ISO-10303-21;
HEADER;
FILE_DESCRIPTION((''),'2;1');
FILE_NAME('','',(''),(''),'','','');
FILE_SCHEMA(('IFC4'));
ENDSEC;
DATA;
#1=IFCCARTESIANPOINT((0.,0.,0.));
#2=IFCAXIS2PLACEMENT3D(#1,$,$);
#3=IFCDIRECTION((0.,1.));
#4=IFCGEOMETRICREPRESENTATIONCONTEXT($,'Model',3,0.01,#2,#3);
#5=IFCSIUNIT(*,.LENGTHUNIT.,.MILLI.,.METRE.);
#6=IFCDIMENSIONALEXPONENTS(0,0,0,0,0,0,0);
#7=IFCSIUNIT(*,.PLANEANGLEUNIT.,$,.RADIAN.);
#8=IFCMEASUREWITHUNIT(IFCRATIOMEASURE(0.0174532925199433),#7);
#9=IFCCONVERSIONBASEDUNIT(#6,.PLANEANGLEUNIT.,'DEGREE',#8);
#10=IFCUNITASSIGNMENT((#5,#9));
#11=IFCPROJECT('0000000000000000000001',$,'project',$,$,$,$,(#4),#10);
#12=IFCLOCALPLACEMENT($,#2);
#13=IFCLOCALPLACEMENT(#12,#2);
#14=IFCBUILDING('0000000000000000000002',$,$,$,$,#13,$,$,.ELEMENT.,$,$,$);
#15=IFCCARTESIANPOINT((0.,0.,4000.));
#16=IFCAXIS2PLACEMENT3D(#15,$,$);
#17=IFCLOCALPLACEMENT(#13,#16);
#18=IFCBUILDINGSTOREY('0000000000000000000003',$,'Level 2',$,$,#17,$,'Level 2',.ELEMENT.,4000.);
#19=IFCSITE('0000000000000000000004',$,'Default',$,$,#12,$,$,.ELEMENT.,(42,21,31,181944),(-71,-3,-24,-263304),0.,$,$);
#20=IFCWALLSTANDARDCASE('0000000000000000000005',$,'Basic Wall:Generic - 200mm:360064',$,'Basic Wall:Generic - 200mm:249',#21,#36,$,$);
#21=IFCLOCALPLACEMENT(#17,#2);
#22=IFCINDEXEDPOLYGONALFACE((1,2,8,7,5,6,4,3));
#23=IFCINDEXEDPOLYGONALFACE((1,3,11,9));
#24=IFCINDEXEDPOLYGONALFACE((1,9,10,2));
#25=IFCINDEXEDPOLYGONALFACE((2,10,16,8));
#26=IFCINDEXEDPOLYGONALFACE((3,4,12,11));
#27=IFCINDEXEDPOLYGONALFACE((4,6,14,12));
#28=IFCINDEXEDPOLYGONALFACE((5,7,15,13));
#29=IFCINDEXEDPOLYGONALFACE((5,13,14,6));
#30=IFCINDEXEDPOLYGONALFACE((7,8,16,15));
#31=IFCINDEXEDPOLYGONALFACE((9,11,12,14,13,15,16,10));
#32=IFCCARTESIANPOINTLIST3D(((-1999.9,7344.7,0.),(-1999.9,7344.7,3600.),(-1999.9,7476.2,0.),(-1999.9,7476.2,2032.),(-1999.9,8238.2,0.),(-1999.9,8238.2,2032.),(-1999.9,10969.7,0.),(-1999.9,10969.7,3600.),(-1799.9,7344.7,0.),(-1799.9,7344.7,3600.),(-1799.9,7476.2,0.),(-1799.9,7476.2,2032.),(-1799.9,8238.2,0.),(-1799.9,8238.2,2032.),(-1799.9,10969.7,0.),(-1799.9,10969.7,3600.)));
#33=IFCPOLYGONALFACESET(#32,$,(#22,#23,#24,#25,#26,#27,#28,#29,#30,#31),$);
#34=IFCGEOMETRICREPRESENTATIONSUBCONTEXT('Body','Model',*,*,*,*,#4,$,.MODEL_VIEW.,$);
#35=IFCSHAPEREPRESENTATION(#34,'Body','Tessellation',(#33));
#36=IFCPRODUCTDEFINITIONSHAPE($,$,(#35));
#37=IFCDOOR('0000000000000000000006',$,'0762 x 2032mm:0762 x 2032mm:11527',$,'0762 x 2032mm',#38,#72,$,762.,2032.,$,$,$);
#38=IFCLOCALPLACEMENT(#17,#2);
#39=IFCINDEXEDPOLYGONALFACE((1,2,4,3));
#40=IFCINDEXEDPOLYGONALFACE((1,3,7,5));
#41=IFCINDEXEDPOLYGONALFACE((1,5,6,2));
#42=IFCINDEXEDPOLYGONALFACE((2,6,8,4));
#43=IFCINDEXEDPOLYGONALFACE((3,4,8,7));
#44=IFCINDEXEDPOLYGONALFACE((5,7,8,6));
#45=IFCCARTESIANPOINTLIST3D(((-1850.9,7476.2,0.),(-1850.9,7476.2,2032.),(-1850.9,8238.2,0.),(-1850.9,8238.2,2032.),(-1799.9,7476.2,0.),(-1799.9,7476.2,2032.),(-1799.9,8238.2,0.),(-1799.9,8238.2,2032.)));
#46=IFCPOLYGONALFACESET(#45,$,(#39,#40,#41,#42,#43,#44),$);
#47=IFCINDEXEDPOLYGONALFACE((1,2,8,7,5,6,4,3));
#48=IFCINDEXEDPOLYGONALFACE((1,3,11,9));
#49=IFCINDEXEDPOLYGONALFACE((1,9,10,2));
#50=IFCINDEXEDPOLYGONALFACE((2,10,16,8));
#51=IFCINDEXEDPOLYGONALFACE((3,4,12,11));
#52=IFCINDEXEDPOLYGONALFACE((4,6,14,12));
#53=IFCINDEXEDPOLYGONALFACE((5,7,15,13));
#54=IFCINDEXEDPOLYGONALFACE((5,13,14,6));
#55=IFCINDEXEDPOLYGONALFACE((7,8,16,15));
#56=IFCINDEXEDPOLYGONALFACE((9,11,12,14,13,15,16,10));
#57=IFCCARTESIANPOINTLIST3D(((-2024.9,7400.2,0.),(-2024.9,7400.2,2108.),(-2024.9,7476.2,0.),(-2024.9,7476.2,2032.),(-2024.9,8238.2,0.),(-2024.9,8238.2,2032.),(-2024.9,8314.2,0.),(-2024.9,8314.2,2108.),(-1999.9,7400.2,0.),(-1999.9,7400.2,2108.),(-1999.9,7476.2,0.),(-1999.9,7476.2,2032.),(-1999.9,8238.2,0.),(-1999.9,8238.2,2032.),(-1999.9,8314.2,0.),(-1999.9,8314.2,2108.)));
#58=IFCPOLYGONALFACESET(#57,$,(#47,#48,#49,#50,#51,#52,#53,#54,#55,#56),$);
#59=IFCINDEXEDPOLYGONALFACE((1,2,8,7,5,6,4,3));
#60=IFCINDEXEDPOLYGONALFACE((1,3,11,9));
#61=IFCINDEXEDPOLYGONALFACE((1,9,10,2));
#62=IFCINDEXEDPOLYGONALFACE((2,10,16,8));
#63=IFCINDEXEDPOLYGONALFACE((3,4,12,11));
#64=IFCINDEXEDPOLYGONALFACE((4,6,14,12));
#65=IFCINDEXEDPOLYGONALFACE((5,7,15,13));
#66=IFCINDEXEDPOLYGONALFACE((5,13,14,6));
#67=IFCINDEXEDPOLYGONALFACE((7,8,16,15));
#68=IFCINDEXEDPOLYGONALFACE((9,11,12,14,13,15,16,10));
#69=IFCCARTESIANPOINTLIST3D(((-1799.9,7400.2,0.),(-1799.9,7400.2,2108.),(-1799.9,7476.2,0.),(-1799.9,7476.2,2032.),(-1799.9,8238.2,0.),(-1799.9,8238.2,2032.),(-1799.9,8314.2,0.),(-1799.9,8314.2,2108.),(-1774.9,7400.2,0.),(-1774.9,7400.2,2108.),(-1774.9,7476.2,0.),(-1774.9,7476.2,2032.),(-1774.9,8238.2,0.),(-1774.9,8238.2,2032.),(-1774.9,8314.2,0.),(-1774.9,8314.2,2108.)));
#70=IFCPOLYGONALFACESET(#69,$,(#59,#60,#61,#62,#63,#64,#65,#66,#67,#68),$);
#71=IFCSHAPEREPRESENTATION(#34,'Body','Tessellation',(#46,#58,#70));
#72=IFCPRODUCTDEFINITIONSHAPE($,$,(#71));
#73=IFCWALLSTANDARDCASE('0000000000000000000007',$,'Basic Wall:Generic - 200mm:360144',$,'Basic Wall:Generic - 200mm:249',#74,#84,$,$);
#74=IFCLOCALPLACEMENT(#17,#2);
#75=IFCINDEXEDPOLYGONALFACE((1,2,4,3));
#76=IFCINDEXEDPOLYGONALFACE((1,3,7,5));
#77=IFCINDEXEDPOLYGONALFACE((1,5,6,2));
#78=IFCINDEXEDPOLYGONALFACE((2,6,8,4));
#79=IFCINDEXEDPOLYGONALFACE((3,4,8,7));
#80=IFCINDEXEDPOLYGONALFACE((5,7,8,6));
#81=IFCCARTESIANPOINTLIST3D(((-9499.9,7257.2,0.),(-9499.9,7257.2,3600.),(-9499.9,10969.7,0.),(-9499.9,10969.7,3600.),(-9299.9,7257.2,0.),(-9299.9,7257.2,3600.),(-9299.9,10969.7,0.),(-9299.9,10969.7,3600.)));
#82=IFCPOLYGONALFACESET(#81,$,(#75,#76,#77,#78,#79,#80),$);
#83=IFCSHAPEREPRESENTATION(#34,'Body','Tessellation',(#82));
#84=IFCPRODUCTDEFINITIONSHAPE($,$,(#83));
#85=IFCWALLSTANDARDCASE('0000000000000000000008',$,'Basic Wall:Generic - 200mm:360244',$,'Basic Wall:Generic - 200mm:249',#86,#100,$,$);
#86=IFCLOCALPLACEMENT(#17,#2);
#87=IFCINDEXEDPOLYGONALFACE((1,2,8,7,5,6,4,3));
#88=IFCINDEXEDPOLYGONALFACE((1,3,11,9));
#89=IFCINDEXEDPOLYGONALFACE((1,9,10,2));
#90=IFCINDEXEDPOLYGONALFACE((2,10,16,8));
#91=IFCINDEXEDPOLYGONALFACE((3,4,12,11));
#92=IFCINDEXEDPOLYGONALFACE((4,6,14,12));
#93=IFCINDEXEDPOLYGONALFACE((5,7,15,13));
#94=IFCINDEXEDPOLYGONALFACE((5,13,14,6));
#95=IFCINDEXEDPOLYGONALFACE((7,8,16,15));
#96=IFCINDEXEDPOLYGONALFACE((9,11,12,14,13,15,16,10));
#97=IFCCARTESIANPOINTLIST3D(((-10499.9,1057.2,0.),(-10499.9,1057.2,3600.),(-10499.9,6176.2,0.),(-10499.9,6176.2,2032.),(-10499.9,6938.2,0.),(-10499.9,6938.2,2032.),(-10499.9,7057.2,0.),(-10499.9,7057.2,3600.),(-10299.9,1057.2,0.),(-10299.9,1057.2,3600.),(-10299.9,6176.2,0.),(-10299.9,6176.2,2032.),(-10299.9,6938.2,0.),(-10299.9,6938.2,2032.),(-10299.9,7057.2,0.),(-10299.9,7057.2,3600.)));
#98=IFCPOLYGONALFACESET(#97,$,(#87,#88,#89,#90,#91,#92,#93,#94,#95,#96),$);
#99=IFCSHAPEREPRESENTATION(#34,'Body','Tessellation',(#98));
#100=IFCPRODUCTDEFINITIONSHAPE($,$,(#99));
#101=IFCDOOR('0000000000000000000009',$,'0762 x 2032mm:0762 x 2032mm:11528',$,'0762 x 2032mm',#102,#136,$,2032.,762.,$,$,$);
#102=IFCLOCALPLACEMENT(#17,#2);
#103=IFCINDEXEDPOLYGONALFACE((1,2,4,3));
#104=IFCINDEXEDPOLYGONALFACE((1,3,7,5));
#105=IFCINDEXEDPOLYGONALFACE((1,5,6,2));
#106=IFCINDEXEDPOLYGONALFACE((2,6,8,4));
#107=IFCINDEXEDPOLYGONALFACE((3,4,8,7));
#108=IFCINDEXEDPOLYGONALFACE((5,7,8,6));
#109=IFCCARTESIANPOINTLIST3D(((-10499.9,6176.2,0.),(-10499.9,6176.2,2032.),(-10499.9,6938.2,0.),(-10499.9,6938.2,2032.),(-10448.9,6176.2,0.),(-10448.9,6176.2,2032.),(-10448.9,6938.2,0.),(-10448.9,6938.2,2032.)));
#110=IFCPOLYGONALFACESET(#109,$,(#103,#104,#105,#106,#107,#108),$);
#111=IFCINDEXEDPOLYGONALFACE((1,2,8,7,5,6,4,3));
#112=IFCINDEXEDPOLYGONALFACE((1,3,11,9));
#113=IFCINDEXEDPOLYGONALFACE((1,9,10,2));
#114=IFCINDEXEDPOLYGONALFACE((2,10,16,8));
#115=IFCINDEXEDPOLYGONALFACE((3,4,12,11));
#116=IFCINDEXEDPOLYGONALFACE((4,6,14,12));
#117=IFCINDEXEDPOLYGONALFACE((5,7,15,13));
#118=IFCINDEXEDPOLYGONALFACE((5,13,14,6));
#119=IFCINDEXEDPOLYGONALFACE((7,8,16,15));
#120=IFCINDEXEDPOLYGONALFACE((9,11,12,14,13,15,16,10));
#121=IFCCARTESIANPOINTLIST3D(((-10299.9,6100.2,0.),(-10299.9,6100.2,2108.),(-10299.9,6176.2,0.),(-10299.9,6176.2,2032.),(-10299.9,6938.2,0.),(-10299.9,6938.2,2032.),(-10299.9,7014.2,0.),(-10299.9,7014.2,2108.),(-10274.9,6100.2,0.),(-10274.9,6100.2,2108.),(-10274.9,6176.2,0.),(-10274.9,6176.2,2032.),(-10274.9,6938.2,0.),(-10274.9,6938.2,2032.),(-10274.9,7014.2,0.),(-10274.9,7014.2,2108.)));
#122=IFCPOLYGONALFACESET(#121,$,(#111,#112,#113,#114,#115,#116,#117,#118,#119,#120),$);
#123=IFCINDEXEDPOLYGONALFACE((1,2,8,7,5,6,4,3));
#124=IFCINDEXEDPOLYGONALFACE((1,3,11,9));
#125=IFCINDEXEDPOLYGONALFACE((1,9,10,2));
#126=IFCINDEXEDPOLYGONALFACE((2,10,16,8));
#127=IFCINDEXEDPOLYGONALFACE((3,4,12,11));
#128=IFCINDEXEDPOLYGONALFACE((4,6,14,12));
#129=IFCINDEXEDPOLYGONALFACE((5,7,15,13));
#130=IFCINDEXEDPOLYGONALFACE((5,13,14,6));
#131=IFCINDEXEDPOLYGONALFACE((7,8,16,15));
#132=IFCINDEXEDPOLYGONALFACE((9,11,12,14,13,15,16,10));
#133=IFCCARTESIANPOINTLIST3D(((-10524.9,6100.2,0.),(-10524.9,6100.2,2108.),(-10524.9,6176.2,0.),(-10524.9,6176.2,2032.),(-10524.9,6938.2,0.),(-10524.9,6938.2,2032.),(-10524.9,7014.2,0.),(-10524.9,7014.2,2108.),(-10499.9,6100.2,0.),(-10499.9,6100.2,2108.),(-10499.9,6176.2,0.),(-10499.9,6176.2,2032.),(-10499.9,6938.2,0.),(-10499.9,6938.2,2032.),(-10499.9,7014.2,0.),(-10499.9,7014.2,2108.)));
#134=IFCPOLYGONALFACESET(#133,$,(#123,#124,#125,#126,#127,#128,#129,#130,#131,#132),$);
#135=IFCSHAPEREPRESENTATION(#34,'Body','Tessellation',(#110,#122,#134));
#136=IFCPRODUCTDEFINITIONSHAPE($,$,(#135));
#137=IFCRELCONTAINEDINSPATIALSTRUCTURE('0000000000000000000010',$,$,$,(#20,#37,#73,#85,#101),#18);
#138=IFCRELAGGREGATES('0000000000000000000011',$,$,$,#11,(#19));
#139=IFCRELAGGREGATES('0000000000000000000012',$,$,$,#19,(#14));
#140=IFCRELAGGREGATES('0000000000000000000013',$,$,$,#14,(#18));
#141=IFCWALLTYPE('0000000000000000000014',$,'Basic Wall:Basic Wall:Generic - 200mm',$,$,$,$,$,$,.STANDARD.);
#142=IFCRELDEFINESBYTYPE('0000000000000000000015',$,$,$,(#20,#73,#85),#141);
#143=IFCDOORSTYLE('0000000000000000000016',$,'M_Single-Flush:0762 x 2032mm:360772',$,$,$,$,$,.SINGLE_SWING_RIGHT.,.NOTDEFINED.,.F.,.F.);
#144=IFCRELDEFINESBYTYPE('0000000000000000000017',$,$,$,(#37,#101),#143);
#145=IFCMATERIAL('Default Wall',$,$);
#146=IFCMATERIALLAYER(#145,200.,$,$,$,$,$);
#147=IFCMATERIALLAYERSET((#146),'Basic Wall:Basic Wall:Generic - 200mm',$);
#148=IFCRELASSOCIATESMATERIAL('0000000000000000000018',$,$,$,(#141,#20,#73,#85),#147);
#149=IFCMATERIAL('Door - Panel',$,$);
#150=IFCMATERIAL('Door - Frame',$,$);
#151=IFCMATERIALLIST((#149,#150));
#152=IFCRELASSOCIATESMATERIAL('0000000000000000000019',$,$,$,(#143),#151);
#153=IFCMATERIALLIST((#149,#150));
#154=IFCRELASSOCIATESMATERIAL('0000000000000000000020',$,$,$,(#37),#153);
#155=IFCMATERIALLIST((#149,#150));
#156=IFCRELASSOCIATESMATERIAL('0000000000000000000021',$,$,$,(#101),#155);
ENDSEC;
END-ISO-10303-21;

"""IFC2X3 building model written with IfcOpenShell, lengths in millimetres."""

from ifc_helpers import new_model, entity, si_unit, converted_unit, direction, frame, frame_2d, origin, place, context, subcontext, project, spatial, polyline, rectangle, outline, extrude, source, transform, mapped, material, material_list, layer, layer_set, layer_usage, type_object, type_shapes, element, fill, save


model = new_model("IFC2X3")

# Units and contexts
model_context = context("Model", 3, precision=0.01, world=origin(), true_north=direction((0.0, 1.0)))
body_context = subcontext(model_context, "Body", "Model", "MODEL_VIEW")
ifc_project = project(units=[si_unit("LENGTHUNIT", "METRE", prefix="MILLI"), converted_unit("PLANEANGLEUNIT", "DEGREE", entity("IfcRatioMeasure", 0.0174532925199433), si_unit("PLANEANGLEUNIT", "RADIAN"), dimensions=[0, 0, 0, 0, 0, 0, 0])], contexts=[model_context])

# Site, building, storey
site_placement = place(None, origin())
site = spatial("IfcSite", under=ifc_project, at=site_placement, Name="Default", CompositionType="ELEMENT", RefLatitude=(42, 21, 31, 181944), RefLongitude=(-71, -3, -24, -263304), RefElevation=0.0)
building_placement = place(site_placement, origin())
building = spatial("IfcBuilding", under=site, at=building_placement, CompositionType="ELEMENT")
storey_placement = place(building_placement, frame((0.0, 0.0, 4000.0)))
storey = spatial("IfcBuildingStorey", under=building, at=storey_placement, Name="Level 2", LongName="Level 2", CompositionType="ELEMENT", Elevation=4000.0)

# Shared definitions
ifc_material_1 = material(Name="Default Wall")
ifc_material_2 = material(Name="Door - Panel")
ifc_material_3 = material(Name="Door - Frame")

# Shared definitions
ifc_layer_1 = layer(ifc_material_1, 200.0)
ifc_layer_set_1 = layer_set([ifc_layer_1], Name="Basic Wall:Basic Wall:Generic - 200mm")
wall_type_1 = type_object("IfcWallType", Name="Basic Wall:Basic Wall:Generic - 200mm", PredefinedType="STANDARD", material=ifc_layer_set_1)

# Shared definitions
ifc_material_list_1 = material_list([ifc_material_2, ifc_material_3])
door_style_1 = type_object("IfcDoorStyle", Name="M_Single-Flush:0762 x 2032mm:360772", ConstructionType="NOTDEFINED", OperationType="SINGLE_SWING_RIGHT", ParameterTakesPrecedence=False, Sizeable=False, material=ifc_material_list_1)
shared_shape_1 = source(origin(), body_context, "Body", "SweptSolid", [
    extrude(rectangle(XDim=762.0, YDim=51.0, at=frame_2d((0.0, 0.0), x_axis=(1.0, 0.0))), frame((381.0, -27.5, 0.0), z_axis=(0.0, 0.0, 1.0), x_axis=(-1.0, 0.0, 0.0)), (0.0, 0.0, 1.0), 2032.0),
    extrude(outline(polyline([(-457.0, -1035.0), (-381.0, -1035.0), (-381.0, 997.0), (381.0, 997.0), (381.0, -1035.0), (457.0, -1035.0), (457.0, 1073.0), (-457.0, 1073.0), (-457.0, -1035.0)])), frame((381.0, -227.0, 1035.0), z_axis=(0.0, 1.0, 0.0), x_axis=(-1.0, 0.0, 0.0)), (0.0, 0.0, 1.0), 25.0),
    extrude(outline(polyline([(-1073.0, -457.0), (1035.0, -457.0), (1035.0, -381.0), (-997.0, -381.0), (-997.0, 381.0), (1035.0, 381.0), (1035.0, 457.0), (-1073.0, 457.0), (-1073.0, -457.0)])), frame((381.0, -2.0, 1035.0), z_axis=(0.0, 1.0, 0.0), x_axis=(0.0, 0.0, -1.0)), (0.0, 0.0, 1.0), 25.0),
])
type_shapes(door_style_1, [shared_shape_1])

# Wall, opening, door
ifc_layer_usage_1 = layer_usage(ifc_layer_set_1, "AXIS2", "NEGATIVE", 100.0)
wall_1_placement = place(storey_placement, frame((-1899.9, 10969.7, 0.0), z_axis=(0.0, 0.0, 1.0), x_axis=(0.0, -1.0, 0.0)))
wall_1 = element("IfcWallStandardCase", 1, at=wall_1_placement, inside=storey, type_object=wall_type_1, material=ifc_layer_usage_1, Name="Basic Wall:Generic - 200mm:360064", ObjectType="Basic Wall:Generic - 200mm:249", context=body_context, shape_type="SweptSolid", body=[
    extrude(rectangle(XDim=3625.0, YDim=200.0, at=frame_2d((1812.5, 0.0), x_axis=(-1.0, 0.0))), origin(), (0.0, 0.0, 1.0), 3600.0),
])
opening_1_placement = place(wall_1_placement, frame((10969.7, 1899.9, 0.0), z_axis=(0.0, 0.0, 1.0), x_axis=(0.0, 1.0, 0.0)))
opening_1 = element("IfcOpeningElement", 2, at=opening_1_placement, cuts=wall_1, ObjectType="Opening", context=body_context, shape_type="SweptSolid", body=[
    extrude(rectangle(XDim=2032.0, YDim=762.0, at=frame_2d((0.0, 0.0), x_axis=(1.0, 0.0))), frame((-2001.9, 7857.2, 1016.0), z_axis=(1.0, 0.0, 0.0), x_axis=(0.0, 0.0, -1.0)), (0.0, 0.0, 1.0), 204.0),
])
ifc_material_list_2 = material_list([ifc_material_2, ifc_material_3])
door_1_placement = place(opening_1_placement, frame((-1797.9, 8238.2, 0.0), z_axis=(0.0, 0.0, 1.0), x_axis=(0.0, -1.0, 0.0)))
door_1 = element("IfcDoor", 3, at=door_1_placement, inside=storey, type_object=door_style_1, material=ifc_material_list_2, Name="0762 x 2032mm:0762 x 2032mm:11527", ObjectType="0762 x 2032mm", OverallHeight=762.0, OverallWidth=2032.0, context=body_context, shape_type="MappedRepresentation", body=[
    mapped(shared_shape_1, transform((0.0, 0.0, 0.0), scale=1.0)),
])
fill(opening_1, door_1)

# Wall
ifc_layer_usage_2 = layer_usage(ifc_layer_set_1, "AXIS2", "NEGATIVE", 100.0)
wall_2_placement = place(storey_placement, frame((-9399.9, 7257.2, 0.0), z_axis=(0.0, 0.0, 1.0), x_axis=(0.0, 1.0, 0.0)))
element("IfcWallStandardCase", 4, at=wall_2_placement, inside=storey, type_object=wall_type_1, material=ifc_layer_usage_2, Name="Basic Wall:Generic - 200mm:360144", ObjectType="Basic Wall:Generic - 200mm:249", context=body_context, shape_type="SweptSolid", body=[
    extrude(rectangle(XDim=3712.5, YDim=200.0, at=frame_2d((1856.2, 0.0), x_axis=(-1.0, 0.0))), origin(), (0.0, 0.0, 1.0), 3600.0),
])

# Wall, opening, door
ifc_layer_usage_3 = layer_usage(ifc_layer_set_1, "AXIS2", "NEGATIVE", 100.0)
wall_3_placement = place(storey_placement, frame((-10399.9, 7057.2, 0.0), z_axis=(0.0, 0.0, 1.0), x_axis=(0.0, -1.0, 0.0)))
wall_3 = element("IfcWallStandardCase", 5, at=wall_3_placement, inside=storey, type_object=wall_type_1, material=ifc_layer_usage_3, Name="Basic Wall:Generic - 200mm:360244", ObjectType="Basic Wall:Generic - 200mm:249", context=body_context, shape_type="SweptSolid", body=[
    extrude(rectangle(XDim=6000.0, YDim=200.0, at=frame_2d((3000.0, 0.0), x_axis=(-1.0, 0.0))), origin(), (0.0, 0.0, 1.0), 3600.0),
])
opening_2_placement = place(wall_3_placement, frame((7057.2, 10399.9, 0.0), z_axis=(0.0, 0.0, 1.0), x_axis=(0.0, 1.0, 0.0)))
opening_2 = element("IfcOpeningElement", 6, at=opening_2_placement, cuts=wall_3, ObjectType="Opening", context=body_context, shape_type="SweptSolid", body=[
    extrude(rectangle(XDim=2032.0, YDim=762.0, at=frame_2d((0.0, 0.0), x_axis=(0.0, 1.0))), frame((-10501.9, 6557.2, 1016.0), z_axis=(1.0, 0.0, 0.0), x_axis=(0.0, -1.0, 0.0)), (0.0, 0.0, 1.0), 204.0),
])
ifc_material_list_3 = material_list([ifc_material_2, ifc_material_3])
door_2_placement = place(opening_2_placement, frame((-10501.9, 6176.2, 0.0), z_axis=(0.0, 0.0, 1.0), x_axis=(0.0, 1.0, 0.0)))
door_2 = element("IfcDoor", 7, at=door_2_placement, inside=storey, type_object=door_style_1, material=ifc_material_list_3, Name="0762 x 2032mm:0762 x 2032mm:11528", ObjectType="0762 x 2032mm", OverallHeight=2032.0, OverallWidth=762.0, context=body_context, shape_type="MappedRepresentation", body=[
    mapped(shared_shape_1, transform((0.0, 0.0, 0.0), scale=1.0)),
])
fill(opening_2, door_2)

save(model, "model.ifc")
